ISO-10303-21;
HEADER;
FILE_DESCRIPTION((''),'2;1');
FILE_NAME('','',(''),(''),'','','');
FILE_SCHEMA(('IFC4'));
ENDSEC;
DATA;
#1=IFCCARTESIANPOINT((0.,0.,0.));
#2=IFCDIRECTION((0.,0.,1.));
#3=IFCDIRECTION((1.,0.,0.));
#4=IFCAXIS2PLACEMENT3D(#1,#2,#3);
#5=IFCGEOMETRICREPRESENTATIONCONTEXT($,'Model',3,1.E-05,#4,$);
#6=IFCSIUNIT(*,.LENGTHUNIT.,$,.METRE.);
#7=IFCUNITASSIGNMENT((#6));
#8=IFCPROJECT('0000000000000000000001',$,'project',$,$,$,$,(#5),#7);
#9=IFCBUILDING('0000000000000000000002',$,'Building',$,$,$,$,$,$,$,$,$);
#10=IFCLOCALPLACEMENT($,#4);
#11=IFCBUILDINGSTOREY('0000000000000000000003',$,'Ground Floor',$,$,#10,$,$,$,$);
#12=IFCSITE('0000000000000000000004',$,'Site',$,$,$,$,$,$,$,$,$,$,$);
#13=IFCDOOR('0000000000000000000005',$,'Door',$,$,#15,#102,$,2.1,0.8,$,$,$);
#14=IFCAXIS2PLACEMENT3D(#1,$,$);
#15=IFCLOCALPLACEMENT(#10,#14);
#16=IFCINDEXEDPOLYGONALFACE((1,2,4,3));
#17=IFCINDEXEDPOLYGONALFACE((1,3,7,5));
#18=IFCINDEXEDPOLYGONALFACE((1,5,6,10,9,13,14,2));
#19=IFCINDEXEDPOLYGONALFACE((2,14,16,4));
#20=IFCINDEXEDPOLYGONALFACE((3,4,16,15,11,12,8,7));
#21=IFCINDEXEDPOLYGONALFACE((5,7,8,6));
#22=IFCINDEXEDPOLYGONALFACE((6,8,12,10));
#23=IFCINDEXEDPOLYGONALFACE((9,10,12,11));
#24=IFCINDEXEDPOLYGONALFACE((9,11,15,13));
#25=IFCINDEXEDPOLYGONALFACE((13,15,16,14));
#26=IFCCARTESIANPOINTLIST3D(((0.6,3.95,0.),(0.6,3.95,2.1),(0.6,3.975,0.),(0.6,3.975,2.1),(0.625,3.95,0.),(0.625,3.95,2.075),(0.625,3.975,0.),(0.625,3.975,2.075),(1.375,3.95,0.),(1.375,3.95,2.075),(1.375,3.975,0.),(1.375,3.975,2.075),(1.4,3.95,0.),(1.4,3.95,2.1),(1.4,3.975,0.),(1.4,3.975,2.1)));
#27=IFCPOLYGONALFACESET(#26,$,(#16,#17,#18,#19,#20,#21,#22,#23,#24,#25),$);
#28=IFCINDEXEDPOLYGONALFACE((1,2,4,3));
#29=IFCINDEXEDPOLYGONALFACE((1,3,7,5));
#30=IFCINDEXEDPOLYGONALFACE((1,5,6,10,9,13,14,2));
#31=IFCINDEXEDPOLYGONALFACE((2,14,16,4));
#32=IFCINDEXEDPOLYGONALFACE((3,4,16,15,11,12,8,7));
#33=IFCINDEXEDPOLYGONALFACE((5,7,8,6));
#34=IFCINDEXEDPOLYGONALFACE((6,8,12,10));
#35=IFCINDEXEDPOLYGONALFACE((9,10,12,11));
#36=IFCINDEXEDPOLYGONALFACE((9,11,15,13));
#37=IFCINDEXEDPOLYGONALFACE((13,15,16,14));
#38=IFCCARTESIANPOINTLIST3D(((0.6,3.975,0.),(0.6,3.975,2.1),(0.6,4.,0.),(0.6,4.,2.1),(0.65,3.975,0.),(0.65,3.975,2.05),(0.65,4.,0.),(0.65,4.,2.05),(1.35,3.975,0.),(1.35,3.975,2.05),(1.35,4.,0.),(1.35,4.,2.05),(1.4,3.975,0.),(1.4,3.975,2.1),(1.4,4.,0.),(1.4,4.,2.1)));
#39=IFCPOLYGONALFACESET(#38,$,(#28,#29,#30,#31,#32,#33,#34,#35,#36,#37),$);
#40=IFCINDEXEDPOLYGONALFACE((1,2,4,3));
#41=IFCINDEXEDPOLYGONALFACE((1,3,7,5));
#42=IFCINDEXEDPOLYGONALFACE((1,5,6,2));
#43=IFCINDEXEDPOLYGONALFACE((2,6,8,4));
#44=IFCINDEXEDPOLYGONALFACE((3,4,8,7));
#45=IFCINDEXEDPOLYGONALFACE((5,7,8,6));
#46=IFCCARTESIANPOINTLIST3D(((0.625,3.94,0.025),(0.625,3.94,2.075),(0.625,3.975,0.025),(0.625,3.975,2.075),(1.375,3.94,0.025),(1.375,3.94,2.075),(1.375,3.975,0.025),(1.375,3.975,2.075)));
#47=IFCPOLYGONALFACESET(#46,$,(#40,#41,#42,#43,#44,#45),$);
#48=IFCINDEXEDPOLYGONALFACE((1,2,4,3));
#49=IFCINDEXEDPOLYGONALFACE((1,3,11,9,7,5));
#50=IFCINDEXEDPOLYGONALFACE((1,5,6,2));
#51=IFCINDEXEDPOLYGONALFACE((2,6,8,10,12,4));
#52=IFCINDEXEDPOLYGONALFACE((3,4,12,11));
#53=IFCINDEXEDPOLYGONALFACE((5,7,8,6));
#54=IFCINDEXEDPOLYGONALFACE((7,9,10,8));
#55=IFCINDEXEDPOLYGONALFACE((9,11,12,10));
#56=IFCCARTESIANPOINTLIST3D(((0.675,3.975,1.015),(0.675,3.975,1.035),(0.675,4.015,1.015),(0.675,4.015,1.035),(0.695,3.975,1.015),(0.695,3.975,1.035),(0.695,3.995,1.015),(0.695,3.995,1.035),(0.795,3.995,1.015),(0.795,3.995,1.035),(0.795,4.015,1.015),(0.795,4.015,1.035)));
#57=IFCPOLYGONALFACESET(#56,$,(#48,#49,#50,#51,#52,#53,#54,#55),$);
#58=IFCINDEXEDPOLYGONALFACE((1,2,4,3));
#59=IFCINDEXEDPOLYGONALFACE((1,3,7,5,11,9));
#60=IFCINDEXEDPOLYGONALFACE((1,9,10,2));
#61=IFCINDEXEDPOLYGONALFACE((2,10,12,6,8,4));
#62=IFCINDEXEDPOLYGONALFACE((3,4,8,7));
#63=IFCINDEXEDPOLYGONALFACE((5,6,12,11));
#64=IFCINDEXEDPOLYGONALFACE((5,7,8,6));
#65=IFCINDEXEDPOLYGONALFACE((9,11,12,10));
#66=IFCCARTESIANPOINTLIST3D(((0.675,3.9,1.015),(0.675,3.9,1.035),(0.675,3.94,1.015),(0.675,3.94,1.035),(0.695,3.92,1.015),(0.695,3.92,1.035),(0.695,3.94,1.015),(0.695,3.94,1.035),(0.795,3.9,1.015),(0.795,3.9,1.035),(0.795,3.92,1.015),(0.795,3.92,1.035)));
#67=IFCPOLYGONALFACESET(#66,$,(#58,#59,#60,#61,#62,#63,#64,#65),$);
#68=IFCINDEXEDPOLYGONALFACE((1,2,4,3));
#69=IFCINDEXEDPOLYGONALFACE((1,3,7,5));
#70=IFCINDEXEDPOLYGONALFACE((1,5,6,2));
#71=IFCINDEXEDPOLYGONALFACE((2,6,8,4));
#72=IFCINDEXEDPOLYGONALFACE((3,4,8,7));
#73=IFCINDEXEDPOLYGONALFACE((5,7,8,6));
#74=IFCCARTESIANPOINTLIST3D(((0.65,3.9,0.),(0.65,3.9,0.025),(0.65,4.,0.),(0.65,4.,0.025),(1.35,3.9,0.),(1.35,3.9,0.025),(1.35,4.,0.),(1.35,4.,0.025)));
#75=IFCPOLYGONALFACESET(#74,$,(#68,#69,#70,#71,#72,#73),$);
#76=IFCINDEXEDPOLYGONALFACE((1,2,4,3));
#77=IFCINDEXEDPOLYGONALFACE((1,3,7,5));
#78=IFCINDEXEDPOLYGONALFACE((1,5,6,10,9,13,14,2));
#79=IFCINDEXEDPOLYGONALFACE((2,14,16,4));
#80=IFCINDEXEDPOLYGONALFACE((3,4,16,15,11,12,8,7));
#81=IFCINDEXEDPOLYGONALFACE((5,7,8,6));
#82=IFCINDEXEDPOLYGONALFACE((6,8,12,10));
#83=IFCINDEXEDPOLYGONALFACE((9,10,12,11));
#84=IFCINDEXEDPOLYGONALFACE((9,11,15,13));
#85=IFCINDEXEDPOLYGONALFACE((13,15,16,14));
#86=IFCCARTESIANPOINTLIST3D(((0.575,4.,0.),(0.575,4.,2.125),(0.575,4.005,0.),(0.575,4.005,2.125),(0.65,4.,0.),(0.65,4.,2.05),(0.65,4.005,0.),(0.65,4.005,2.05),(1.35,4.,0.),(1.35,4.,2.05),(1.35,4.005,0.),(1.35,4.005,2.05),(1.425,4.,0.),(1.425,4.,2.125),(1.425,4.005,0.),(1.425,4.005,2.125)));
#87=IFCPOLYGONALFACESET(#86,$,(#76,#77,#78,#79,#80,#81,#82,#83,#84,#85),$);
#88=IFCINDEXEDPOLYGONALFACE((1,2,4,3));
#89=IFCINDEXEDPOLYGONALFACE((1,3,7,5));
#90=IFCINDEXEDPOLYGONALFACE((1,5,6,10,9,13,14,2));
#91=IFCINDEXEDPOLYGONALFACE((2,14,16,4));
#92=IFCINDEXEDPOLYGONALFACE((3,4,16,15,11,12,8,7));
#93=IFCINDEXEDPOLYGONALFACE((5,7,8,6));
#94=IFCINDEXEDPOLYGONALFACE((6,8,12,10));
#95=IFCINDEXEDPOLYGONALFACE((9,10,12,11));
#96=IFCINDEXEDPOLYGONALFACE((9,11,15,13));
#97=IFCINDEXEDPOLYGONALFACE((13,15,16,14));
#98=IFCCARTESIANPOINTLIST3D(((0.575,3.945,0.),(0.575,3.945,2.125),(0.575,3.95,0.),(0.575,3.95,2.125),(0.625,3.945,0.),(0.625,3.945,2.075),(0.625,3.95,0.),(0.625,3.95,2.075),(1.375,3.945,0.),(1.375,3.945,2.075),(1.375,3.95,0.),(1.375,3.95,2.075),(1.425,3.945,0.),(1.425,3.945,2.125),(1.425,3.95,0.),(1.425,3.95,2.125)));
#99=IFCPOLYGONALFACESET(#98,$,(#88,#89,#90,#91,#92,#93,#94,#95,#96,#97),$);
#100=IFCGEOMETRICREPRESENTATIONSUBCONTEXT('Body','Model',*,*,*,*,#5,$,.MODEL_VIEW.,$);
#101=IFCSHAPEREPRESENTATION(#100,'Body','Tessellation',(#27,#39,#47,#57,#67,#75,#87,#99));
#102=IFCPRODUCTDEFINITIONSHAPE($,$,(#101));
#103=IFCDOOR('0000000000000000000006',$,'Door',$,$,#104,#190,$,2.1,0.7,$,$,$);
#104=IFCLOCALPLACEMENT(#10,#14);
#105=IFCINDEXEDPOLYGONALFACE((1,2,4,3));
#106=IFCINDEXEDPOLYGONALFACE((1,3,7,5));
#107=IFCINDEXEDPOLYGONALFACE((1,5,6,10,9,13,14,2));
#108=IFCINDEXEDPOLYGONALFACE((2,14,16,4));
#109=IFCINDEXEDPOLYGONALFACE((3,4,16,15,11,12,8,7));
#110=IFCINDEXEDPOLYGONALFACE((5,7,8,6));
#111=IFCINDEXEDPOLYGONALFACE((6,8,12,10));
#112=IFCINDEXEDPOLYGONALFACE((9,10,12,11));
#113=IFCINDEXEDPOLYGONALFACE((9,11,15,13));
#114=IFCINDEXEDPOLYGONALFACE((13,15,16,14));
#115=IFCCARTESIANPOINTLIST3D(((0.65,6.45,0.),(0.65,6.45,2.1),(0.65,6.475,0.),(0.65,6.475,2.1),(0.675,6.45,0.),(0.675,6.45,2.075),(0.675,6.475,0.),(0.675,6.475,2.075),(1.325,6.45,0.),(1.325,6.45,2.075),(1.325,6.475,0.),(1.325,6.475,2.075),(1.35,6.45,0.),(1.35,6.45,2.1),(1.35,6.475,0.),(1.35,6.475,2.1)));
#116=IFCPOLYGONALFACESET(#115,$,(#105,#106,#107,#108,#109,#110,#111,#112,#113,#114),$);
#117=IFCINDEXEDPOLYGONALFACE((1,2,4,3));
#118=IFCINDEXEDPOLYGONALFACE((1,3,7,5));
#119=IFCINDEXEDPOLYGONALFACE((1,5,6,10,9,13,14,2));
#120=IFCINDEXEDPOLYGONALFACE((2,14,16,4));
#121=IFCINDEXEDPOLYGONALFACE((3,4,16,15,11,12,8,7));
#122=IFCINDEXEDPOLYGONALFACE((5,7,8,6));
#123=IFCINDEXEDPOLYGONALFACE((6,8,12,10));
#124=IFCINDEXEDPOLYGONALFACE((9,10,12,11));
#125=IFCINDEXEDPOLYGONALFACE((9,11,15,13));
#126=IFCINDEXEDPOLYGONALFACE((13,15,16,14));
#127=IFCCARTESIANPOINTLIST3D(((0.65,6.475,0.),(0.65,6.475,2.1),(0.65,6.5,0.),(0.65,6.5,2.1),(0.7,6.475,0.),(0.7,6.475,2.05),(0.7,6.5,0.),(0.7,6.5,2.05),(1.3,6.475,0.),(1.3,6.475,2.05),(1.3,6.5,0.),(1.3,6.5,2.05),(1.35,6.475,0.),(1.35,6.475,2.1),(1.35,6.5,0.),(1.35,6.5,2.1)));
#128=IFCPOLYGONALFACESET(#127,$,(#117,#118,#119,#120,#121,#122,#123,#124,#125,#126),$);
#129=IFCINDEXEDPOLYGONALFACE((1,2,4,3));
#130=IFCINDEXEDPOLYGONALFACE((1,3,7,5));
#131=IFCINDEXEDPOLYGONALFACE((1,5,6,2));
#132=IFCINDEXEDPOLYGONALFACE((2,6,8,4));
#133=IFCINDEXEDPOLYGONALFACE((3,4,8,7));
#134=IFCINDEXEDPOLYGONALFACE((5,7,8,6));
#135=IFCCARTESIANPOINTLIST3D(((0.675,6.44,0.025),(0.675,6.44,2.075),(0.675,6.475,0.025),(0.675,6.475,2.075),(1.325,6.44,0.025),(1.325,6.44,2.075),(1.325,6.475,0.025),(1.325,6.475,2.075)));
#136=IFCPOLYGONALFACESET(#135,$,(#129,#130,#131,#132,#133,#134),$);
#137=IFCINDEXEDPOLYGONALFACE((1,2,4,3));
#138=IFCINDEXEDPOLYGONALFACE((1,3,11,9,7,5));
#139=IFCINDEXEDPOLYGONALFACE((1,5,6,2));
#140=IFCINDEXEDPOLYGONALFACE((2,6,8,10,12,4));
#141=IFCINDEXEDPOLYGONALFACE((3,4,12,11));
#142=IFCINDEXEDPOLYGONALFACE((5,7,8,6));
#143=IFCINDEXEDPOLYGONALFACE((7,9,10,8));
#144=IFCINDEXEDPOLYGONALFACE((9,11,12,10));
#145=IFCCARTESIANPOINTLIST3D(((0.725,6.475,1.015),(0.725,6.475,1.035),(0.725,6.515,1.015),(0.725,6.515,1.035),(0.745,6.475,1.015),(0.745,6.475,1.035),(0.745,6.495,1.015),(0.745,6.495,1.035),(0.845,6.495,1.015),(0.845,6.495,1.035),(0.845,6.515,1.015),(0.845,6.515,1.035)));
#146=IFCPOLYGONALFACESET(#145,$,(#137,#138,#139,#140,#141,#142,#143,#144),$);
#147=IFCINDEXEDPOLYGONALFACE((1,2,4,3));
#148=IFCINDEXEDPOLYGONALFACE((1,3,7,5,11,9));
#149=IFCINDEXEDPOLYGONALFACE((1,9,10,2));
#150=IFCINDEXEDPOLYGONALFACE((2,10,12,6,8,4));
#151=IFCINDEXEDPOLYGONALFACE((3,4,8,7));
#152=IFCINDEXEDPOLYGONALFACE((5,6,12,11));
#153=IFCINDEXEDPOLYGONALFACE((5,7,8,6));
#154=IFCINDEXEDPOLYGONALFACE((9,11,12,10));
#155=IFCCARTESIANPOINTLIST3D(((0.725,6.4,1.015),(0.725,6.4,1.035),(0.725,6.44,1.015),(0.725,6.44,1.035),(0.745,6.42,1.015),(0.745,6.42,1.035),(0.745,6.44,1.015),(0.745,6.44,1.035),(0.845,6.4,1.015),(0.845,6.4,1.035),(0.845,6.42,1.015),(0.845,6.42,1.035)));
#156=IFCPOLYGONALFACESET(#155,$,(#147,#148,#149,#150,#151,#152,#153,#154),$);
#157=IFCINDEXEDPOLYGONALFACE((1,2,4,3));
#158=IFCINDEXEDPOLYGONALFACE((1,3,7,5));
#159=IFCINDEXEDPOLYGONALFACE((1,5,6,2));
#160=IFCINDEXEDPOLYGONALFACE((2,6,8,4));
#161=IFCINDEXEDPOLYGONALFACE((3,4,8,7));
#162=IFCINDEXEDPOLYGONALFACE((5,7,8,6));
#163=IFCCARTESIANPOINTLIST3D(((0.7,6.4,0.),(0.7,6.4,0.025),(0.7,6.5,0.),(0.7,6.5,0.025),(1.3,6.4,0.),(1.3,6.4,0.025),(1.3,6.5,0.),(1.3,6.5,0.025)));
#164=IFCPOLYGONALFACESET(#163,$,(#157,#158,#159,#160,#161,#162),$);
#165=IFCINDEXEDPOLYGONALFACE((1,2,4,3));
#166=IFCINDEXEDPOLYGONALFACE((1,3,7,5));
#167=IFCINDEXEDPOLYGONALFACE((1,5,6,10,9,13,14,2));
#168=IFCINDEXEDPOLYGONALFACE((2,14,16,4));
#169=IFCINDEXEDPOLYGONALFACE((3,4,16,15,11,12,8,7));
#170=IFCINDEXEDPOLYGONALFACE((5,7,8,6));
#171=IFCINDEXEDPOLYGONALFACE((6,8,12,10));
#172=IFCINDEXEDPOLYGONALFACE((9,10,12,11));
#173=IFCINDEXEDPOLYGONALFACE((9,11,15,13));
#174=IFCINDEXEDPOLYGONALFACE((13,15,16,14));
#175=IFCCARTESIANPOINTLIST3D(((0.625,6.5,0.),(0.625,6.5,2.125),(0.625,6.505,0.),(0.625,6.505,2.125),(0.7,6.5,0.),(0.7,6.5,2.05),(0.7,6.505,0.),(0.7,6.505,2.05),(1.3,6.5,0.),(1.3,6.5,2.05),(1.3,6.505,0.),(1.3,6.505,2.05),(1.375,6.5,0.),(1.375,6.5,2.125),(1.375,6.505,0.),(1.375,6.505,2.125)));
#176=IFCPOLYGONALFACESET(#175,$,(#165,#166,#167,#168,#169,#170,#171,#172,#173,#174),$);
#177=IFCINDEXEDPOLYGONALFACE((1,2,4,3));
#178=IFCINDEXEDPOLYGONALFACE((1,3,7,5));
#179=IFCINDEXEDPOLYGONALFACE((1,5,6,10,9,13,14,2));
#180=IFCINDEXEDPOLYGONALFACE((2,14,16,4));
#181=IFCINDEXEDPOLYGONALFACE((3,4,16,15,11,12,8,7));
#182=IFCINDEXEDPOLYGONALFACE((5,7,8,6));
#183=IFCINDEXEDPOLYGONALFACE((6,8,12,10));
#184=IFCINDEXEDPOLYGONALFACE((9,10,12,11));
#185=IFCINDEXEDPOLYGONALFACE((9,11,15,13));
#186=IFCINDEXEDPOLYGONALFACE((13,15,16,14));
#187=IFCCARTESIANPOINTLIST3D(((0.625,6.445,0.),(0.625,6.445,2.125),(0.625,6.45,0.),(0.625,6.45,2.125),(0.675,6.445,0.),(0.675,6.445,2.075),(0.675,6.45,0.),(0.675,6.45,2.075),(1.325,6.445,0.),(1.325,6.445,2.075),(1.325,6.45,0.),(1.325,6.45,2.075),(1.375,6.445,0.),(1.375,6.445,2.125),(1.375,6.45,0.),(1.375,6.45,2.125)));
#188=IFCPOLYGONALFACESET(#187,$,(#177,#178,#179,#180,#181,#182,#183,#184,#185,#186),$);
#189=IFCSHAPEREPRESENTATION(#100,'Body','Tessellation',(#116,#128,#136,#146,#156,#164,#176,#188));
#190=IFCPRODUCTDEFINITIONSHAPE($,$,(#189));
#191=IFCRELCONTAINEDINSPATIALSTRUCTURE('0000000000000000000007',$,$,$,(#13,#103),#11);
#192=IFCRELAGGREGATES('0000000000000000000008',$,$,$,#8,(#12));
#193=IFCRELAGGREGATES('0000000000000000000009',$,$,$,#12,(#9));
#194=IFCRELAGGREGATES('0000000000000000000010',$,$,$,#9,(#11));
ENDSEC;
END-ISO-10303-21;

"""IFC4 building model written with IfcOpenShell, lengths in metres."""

from ifc_helpers import new_model, si_unit, frame, origin_with_axes, place, context, subcontext, project, spatial, line, indexed_curve, outline, extrude, element, save


model = new_model("IFC4")

# Units and contexts
model_context = context("Model", 3, precision=1e-05, world=origin_with_axes())
body_context = subcontext(model_context, "Body", "Model", "MODEL_VIEW")
ifc_project = project(units=[si_unit("LENGTHUNIT", "METRE")], contexts=[model_context])

# Site, building, storey
site = spatial("IfcSite", under=ifc_project, Name="Site")
building = spatial("IfcBuilding", under=site, Name="Building")
storey_placement = place(None, origin_with_axes())
storey = spatial("IfcBuildingStorey", under=building, at=storey_placement, Name="Ground Floor")

# Doors
door_1_placement = place(storey_placement, frame((1.4, 4.0, 0.0), z_axis=(0.0, 0.0, 1.0), x_axis=(-1.0, 0.0, 0.0)))
element("IfcDoor", 1, at=door_1_placement, inside=storey, Name="Door", OverallHeight=2.1, OverallWidth=0.8, context=body_context, shape_type="SweptSolid", body=[
    extrude(outline(indexed_curve([(0.0, 0.0), (0.0, 2.1), (0.8, 2.1), (0.8, 0.0), (0.775, 0.0), (0.775, 2.075), (0.025, 2.075), (0.025, 0.0)], segments=[line(1, 2, 3, 4, 5, 6, 7, 8, 1)])), frame((0.0, 0.025, 0.0), z_axis=(0.0, -1.0, 0.0), x_axis=(1.0, 0.0, 0.0)), (0.0, 0.0, -1.0), 0.025),
    extrude(outline(indexed_curve([(0.0, 0.0), (0.0, 2.1), (0.8, 2.1), (0.8, 0.0), (0.75, 0.0), (0.75, 2.05), (0.05, 2.05), (0.05, 0.0)], segments=[line(1, 2, 3, 4, 5, 6, 7, 8, 1)])), frame((0.0, 0.0, 0.0), z_axis=(0.0, -1.0, 0.0), x_axis=(1.0, 0.0, 0.0)), (0.0, 0.0, -1.0), 0.025),
    extrude(outline(indexed_curve([(0.0, 0.0), (0.75, 0.0), (0.75, 0.035), (0.0, 0.035)], segments=[line(1, 2, 3, 4, 1)])), frame((0.025, 0.025, 0.025), z_axis=(0.0, 0.0, 1.0), x_axis=(1.0, 0.0, 0.0)), (0.0, 0.0, 1.0), 2.05),
    extrude(outline(indexed_curve([(0.0, 0.0), (0.0, -0.04), (-0.12, -0.04), (-0.12, -0.02), (-0.02, -0.02), (-0.02, 0.0)], segments=[line(1, 2, 3, 4, 5, 6, 1)])), frame((0.725, 0.025, 1.015), z_axis=(0.0, 0.0, 1.0), x_axis=(1.0, 0.0, 0.0)), (0.0, 0.0, 1.0), 0.02),
    extrude(outline(indexed_curve([(0.0, 0.0), (0.0, 0.04), (-0.12, 0.04), (-0.12, 0.02), (-0.02, 0.02), (-0.02, 0.0)], segments=[line(1, 2, 3, 4, 5, 6, 1)])), frame((0.725, 0.06, 1.015), z_axis=(0.0, 0.0, 1.0), x_axis=(1.0, 0.0, 0.0)), (0.0, 0.0, 1.0), 0.02),
    extrude(outline(indexed_curve([(0.0, 0.0), (0.7, 0.0), (0.7, 0.1), (0.0, 0.1)], segments=[line(1, 2, 3, 4, 1)])), frame((0.05, 0.0, 0.0), z_axis=(0.0, 0.0, 1.0), x_axis=(1.0, 0.0, 0.0)), (0.0, 0.0, 1.0), 0.025),
    extrude(outline(indexed_curve([(0.0, 0.0), (0.0, 2.125), (0.85, 2.125), (0.85, 0.0), (0.775, 0.0), (0.775, 2.05), (0.075, 2.05), (0.075, 0.0)], segments=[line(1, 2, 3, 4, 5, 6, 7, 8, 1)])), frame((-0.025, -0.005, 0.0), z_axis=(0.0, -1.0, 0.0), x_axis=(1.0, 0.0, 0.0)), (0.0, 0.0, -1.0), 0.005),
    extrude(outline(indexed_curve([(0.0, 0.0), (0.0, 2.125), (0.85, 2.125), (0.85, 0.0), (0.8, 0.0), (0.8, 2.075), (0.05, 2.075), (0.05, 0.0)], segments=[line(1, 2, 3, 4, 5, 6, 7, 8, 1)])), frame((-0.025, 0.05, 0.0), z_axis=(0.0, -1.0, 0.0), x_axis=(1.0, 0.0, 0.0)), (0.0, 0.0, -1.0), 0.005),
])
door_2_placement = place(storey_placement, frame((1.35, 6.5, 0.0), z_axis=(0.0, 0.0, 1.0), x_axis=(-1.0, 0.0, 0.0)))
element("IfcDoor", 2, at=door_2_placement, inside=storey, Name="Door", OverallHeight=2.1, OverallWidth=0.7, context=body_context, shape_type="SweptSolid", body=[
    extrude(outline(indexed_curve([(0.0, 0.0), (0.0, 2.1), (0.7, 2.1), (0.7, 0.0), (0.675, 0.0), (0.675, 2.075), (0.025, 2.075), (0.025, 0.0)], segments=[line(1, 2, 3, 4, 5, 6, 7, 8, 1)])), frame((0.0, 0.025, 0.0), z_axis=(0.0, -1.0, 0.0), x_axis=(1.0, 0.0, 0.0)), (0.0, 0.0, -1.0), 0.025),
    extrude(outline(indexed_curve([(0.0, 0.0), (0.0, 2.1), (0.7, 2.1), (0.7, 0.0), (0.65, 0.0), (0.65, 2.05), (0.05, 2.05), (0.05, 0.0)], segments=[line(1, 2, 3, 4, 5, 6, 7, 8, 1)])), frame((0.0, 0.0, 0.0), z_axis=(0.0, -1.0, 0.0), x_axis=(1.0, 0.0, 0.0)), (0.0, 0.0, -1.0), 0.025),
    extrude(outline(indexed_curve([(0.0, 0.0), (0.65, 0.0), (0.65, 0.035), (0.0, 0.035)], segments=[line(1, 2, 3, 4, 1)])), frame((0.025, 0.025, 0.025), z_axis=(0.0, 0.0, 1.0), x_axis=(1.0, 0.0, 0.0)), (0.0, 0.0, 1.0), 2.05),
    extrude(outline(indexed_curve([(0.0, 0.0), (0.0, -0.04), (-0.12, -0.04), (-0.12, -0.02), (-0.02, -0.02), (-0.02, 0.0)], segments=[line(1, 2, 3, 4, 5, 6, 1)])), frame((0.625, 0.025, 1.015), z_axis=(0.0, 0.0, 1.0), x_axis=(1.0, 0.0, 0.0)), (0.0, 0.0, 1.0), 0.02),
    extrude(outline(indexed_curve([(0.0, 0.0), (0.0, 0.04), (-0.12, 0.04), (-0.12, 0.02), (-0.02, 0.02), (-0.02, 0.0)], segments=[line(1, 2, 3, 4, 5, 6, 1)])), frame((0.625, 0.06, 1.015), z_axis=(0.0, 0.0, 1.0), x_axis=(1.0, 0.0, 0.0)), (0.0, 0.0, 1.0), 0.02),
    extrude(outline(indexed_curve([(0.0, 0.0), (0.6, 0.0), (0.6, 0.1), (0.0, 0.1)], segments=[line(1, 2, 3, 4, 1)])), frame((0.05, 0.0, 0.0), z_axis=(0.0, 0.0, 1.0), x_axis=(1.0, 0.0, 0.0)), (0.0, 0.0, 1.0), 0.025),
    extrude(outline(indexed_curve([(0.0, 0.0), (0.0, 2.125), (0.75, 2.125), (0.75, 0.0), (0.675, 0.0), (0.675, 2.05), (0.075, 2.05), (0.075, 0.0)], segments=[line(1, 2, 3, 4, 5, 6, 7, 8, 1)])), frame((-0.025, -0.005, 0.0), z_axis=(0.0, -1.0, 0.0), x_axis=(1.0, 0.0, 0.0)), (0.0, 0.0, -1.0), 0.005),
    extrude(outline(indexed_curve([(0.0, 0.0), (0.0, 2.125), (0.75, 2.125), (0.75, 0.0), (0.7, 0.0), (0.7, 2.075), (0.05, 2.075), (0.05, 0.0)], segments=[line(1, 2, 3, 4, 5, 6, 7, 8, 1)])), frame((-0.025, 0.05, 0.0), z_axis=(0.0, -1.0, 0.0), x_axis=(1.0, 0.0, 0.0)), (0.0, 0.0, -1.0), 0.005),
])

save(model, "model.ifc")
